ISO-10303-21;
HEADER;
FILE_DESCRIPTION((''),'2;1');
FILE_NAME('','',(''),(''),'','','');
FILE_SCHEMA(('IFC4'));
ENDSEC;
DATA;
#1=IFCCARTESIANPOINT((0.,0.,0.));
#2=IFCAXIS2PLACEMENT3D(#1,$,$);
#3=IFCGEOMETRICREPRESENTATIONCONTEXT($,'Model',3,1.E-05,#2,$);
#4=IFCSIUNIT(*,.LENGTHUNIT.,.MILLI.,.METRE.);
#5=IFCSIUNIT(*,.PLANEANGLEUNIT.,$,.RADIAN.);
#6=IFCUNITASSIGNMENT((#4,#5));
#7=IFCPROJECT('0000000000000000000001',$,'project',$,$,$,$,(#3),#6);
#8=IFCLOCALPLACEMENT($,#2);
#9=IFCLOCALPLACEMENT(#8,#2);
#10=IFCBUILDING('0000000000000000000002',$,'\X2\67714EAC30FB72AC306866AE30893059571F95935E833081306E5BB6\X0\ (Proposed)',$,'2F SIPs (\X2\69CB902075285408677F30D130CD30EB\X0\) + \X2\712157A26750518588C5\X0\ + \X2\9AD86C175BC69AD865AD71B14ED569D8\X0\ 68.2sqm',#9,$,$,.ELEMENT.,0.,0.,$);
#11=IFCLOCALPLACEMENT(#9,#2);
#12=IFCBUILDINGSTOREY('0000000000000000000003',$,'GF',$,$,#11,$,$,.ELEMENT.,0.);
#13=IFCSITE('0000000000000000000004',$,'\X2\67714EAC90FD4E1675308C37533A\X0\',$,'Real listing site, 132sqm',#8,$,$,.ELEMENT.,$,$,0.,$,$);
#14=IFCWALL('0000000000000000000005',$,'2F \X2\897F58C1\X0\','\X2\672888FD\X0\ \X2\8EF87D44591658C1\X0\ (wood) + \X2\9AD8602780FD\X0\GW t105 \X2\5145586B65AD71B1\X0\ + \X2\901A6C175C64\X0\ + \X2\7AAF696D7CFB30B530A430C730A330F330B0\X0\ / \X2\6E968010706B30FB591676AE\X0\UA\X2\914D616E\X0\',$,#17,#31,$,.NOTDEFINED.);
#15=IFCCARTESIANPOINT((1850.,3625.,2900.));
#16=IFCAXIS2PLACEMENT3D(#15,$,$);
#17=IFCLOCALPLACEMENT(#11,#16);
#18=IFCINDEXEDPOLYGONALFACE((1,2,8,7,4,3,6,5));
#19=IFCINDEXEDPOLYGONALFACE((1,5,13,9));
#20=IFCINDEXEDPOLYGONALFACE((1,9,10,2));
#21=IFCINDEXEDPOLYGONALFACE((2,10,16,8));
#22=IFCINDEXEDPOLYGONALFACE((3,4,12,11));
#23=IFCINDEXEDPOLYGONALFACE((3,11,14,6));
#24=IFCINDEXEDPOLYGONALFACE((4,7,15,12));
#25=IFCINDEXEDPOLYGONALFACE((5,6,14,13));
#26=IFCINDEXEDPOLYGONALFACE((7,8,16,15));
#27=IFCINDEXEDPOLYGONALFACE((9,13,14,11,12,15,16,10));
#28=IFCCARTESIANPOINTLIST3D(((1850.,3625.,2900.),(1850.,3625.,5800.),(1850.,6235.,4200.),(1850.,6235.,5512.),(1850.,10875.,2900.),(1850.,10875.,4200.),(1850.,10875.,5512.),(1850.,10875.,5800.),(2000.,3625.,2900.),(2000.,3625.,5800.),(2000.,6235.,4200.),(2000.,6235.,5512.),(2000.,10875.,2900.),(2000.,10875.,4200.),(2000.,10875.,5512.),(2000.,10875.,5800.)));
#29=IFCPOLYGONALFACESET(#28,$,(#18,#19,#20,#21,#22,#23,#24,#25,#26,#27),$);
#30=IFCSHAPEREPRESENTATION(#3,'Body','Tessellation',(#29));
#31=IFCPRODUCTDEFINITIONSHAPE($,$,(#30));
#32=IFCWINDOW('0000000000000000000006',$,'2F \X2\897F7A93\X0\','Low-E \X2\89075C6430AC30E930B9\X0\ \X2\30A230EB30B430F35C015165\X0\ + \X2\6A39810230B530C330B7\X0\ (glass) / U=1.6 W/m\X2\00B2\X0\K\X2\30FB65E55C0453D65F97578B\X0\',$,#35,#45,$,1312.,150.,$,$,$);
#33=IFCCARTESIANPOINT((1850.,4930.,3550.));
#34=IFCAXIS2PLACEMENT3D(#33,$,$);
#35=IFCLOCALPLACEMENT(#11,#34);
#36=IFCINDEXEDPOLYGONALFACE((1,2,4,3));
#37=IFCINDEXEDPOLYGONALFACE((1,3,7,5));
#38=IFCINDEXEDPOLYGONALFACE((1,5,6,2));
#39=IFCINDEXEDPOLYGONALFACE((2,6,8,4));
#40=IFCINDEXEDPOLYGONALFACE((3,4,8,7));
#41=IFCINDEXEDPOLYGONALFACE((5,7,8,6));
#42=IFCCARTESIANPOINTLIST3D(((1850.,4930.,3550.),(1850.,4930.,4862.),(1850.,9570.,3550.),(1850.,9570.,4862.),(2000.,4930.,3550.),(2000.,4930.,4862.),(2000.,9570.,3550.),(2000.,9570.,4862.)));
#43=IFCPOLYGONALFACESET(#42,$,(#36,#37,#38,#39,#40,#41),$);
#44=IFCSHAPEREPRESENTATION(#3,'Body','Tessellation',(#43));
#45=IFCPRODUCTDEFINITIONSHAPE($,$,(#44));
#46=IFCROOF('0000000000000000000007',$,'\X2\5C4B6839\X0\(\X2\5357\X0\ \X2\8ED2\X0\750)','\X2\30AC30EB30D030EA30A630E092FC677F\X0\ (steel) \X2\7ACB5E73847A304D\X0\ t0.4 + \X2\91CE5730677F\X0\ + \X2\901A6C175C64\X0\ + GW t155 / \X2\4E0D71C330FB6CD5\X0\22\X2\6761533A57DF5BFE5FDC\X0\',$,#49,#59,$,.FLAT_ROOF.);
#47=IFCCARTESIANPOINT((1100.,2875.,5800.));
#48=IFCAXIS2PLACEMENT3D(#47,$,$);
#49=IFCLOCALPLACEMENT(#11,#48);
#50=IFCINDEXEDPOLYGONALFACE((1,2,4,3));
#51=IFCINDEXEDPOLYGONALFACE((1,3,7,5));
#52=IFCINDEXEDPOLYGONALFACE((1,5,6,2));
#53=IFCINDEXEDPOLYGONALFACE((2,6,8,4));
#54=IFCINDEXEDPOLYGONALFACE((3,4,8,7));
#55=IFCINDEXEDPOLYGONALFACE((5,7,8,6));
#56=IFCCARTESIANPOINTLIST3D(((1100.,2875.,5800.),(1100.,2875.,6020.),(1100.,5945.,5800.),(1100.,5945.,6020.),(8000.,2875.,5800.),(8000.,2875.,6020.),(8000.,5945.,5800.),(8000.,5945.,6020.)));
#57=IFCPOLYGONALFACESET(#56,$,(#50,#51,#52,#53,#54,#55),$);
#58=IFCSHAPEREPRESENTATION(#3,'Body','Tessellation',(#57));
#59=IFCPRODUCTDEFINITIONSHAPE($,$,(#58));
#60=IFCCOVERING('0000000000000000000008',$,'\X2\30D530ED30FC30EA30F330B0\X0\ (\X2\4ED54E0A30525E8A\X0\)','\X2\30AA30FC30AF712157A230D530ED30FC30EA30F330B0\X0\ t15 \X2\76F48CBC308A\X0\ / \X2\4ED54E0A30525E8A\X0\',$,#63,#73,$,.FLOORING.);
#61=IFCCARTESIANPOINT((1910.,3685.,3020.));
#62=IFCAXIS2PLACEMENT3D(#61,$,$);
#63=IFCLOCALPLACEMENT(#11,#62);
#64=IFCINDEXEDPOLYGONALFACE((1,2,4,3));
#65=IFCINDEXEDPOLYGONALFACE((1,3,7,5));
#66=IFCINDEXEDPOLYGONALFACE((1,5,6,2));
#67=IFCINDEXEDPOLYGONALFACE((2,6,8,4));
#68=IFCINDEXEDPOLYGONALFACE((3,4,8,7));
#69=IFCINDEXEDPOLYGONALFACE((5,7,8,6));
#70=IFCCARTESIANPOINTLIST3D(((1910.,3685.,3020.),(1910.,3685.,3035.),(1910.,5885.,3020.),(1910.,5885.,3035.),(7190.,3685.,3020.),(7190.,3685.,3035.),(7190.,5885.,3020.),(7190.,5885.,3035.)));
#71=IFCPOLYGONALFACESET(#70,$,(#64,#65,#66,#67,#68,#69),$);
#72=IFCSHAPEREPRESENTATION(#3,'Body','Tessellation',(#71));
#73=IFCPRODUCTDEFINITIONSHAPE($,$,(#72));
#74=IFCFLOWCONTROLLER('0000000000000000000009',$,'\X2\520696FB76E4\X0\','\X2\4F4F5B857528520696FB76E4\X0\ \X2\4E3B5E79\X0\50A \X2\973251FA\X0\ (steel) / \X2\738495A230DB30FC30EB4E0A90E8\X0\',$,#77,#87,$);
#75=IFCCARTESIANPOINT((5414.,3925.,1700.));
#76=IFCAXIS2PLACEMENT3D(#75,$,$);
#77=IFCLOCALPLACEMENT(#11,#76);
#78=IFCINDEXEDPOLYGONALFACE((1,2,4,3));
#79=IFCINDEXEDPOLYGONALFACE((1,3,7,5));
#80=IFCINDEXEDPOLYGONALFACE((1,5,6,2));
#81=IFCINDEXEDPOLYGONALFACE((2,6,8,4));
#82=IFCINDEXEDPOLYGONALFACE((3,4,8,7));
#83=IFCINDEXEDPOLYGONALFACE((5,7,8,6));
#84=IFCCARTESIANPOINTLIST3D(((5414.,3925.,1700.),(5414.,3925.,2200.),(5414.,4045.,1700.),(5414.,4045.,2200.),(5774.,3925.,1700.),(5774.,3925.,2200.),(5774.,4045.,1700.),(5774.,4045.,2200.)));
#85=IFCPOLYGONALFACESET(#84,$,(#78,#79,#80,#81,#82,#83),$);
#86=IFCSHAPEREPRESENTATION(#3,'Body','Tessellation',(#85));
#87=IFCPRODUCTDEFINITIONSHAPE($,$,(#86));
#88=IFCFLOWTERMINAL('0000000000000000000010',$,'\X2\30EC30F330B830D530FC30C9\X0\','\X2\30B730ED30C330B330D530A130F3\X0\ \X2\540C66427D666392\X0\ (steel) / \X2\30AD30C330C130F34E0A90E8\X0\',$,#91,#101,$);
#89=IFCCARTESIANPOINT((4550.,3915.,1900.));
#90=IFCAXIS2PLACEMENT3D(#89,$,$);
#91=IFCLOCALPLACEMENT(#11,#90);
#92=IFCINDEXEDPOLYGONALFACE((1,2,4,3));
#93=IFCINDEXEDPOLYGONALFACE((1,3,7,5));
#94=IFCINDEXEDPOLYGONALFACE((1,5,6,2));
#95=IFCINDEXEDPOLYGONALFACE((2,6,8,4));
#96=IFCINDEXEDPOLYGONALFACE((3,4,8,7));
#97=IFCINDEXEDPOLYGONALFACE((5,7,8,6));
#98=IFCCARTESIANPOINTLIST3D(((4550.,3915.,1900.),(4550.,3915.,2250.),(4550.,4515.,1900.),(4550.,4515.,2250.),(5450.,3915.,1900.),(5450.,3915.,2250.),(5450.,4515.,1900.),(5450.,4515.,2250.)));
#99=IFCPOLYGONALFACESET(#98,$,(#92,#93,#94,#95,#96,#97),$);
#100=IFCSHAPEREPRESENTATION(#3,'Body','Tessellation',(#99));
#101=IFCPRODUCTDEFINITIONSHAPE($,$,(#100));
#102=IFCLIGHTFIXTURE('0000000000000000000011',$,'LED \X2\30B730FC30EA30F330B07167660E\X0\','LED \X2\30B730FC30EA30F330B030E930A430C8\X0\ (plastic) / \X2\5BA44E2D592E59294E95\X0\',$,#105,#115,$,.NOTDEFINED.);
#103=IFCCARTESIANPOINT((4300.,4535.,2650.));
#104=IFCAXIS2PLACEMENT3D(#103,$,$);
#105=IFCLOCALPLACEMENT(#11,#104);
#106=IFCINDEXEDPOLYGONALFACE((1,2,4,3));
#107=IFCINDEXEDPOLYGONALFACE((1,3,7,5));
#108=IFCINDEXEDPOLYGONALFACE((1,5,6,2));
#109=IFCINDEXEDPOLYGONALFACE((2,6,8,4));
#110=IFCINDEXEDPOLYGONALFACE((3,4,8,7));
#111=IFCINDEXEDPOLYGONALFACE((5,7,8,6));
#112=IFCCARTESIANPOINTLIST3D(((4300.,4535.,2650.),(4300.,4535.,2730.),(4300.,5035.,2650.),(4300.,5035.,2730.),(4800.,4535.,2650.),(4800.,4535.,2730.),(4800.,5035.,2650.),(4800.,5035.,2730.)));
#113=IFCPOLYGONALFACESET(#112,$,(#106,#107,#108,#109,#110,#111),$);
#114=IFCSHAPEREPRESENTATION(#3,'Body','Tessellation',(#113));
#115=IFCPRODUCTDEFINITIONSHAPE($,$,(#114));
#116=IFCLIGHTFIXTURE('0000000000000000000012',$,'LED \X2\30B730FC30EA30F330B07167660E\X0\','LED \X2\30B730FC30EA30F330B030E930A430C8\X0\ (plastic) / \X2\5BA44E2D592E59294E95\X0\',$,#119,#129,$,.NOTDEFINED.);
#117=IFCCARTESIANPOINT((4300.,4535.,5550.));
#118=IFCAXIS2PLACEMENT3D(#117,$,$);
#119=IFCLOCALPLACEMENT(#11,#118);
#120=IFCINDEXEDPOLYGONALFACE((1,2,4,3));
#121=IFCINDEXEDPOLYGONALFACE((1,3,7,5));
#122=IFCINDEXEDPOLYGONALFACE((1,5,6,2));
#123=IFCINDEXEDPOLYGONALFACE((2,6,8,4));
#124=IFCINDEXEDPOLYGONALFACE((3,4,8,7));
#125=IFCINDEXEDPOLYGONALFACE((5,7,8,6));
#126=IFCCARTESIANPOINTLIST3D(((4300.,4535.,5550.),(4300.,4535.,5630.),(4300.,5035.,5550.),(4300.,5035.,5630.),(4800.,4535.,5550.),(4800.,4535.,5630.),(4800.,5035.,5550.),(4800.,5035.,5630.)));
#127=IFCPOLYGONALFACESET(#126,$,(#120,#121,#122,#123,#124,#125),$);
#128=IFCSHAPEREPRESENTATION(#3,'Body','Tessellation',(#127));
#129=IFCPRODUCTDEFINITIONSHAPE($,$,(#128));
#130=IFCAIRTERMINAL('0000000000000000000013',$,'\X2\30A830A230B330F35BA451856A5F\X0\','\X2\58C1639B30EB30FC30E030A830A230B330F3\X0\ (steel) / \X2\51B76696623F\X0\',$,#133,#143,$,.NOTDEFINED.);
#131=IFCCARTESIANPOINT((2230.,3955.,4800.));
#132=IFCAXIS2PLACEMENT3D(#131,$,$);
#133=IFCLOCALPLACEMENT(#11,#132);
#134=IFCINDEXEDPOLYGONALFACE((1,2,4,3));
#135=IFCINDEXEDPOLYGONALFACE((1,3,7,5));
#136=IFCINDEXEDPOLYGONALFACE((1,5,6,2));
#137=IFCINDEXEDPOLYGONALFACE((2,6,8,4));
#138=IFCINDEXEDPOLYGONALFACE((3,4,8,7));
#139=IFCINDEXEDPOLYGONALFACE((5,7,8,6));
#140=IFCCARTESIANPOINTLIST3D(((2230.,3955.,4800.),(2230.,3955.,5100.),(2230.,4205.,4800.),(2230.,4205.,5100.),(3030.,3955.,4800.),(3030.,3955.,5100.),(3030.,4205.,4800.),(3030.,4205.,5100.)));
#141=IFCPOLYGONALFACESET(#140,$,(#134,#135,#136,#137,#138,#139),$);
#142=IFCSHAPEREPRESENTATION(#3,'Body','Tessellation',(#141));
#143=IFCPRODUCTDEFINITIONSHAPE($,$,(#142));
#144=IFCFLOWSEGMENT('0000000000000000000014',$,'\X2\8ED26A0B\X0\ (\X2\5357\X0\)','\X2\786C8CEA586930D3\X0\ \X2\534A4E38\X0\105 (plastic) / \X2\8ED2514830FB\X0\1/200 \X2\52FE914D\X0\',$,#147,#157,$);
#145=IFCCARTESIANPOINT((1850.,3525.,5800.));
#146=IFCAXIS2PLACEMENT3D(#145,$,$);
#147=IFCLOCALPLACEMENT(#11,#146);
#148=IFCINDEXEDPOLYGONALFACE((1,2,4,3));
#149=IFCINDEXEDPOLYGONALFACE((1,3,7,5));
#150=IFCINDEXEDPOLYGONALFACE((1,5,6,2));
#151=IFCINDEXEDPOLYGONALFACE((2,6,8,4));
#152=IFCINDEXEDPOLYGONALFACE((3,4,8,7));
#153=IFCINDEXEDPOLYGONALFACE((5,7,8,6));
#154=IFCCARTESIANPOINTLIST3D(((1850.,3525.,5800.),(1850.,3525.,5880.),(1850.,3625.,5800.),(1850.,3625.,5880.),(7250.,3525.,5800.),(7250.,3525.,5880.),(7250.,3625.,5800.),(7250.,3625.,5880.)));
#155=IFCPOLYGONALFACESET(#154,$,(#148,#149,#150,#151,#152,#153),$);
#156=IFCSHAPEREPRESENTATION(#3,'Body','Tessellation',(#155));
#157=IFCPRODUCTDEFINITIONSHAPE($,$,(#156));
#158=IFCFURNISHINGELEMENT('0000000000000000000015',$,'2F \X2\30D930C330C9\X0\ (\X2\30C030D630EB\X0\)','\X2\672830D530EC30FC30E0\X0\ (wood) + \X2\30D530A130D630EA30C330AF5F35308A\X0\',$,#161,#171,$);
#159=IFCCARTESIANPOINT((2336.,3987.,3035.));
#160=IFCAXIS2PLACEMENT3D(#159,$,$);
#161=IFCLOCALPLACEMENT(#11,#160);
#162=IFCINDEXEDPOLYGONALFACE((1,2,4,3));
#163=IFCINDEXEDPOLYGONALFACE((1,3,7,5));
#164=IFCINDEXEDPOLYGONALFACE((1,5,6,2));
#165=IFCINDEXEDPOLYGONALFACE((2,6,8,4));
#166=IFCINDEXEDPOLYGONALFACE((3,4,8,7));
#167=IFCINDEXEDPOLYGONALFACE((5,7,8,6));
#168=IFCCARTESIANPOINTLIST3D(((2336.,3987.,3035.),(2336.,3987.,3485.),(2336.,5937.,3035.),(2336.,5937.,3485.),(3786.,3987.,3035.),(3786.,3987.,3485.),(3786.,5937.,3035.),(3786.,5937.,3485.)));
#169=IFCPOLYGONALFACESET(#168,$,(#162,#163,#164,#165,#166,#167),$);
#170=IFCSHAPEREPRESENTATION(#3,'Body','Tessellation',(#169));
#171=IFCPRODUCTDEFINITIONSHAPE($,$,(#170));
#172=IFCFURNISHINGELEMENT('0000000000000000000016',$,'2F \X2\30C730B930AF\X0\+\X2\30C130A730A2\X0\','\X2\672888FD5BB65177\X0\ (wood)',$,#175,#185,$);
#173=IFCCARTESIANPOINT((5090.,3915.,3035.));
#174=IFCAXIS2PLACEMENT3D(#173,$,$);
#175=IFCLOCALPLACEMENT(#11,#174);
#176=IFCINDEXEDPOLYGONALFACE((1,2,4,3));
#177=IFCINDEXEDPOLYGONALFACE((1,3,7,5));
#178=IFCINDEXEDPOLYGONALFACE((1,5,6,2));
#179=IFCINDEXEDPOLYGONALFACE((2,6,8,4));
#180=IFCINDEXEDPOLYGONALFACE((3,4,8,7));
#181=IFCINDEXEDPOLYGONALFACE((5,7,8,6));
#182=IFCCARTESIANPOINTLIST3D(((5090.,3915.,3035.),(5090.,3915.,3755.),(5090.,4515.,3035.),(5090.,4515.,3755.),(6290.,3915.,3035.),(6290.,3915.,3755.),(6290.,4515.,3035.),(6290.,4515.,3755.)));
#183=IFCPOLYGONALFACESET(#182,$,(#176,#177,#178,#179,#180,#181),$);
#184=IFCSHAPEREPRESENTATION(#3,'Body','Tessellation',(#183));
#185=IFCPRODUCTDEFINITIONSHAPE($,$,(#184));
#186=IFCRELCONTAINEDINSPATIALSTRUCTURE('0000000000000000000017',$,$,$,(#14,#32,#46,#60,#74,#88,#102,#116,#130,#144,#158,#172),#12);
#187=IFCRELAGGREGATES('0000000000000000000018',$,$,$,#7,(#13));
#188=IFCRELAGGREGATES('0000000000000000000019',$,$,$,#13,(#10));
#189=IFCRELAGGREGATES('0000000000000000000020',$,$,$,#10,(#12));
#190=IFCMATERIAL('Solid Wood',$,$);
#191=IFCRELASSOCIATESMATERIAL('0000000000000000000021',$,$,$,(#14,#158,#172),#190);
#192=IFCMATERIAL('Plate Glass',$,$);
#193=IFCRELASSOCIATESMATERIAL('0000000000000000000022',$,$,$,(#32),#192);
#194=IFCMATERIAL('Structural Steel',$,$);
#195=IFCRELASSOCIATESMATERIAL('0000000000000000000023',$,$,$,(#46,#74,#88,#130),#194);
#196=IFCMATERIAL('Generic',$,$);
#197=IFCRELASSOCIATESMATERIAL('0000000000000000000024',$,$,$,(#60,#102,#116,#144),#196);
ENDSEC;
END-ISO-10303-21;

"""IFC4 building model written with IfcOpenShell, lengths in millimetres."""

from ifc_helpers import new_model, si_unit, frame, frame_2d, origin, place, context, project, spatial, rectangle, extrude, material, element, fill, save


model = new_model("IFC4")

# Units and contexts
model_context = context("Model", 3, precision=1e-05, world=origin())
ifc_project = project(units=[si_unit("LENGTHUNIT", "METRE", prefix="MILLI"), si_unit("PLANEANGLEUNIT", "RADIAN")], contexts=[model_context])

# Site, building, storey
site_placement = place(None, origin())
site = spatial("IfcSite", under=ifc_project, at=site_placement, Name="東京都世田谷区", ObjectType="Real listing site, 132sqm", CompositionType="ELEMENT", RefElevation=0.0)
building_placement = place(site_placement, origin())
building = spatial("IfcBuilding", under=site, at=building_placement, Name="東京・犬と暮らす土間広めの家 (Proposed)", ObjectType="2F SIPs (構造用合板パネル) + 無垢材内装 + 高気密高断熱仕様 68.2sqm", CompositionType="ELEMENT", ElevationOfRefHeight=0.0, ElevationOfTerrain=0.0)
storey_placement = place(building_placement, origin())
storey = spatial("IfcBuildingStorey", under=building, at=storey_placement, Name="GF", CompositionType="ELEMENT", Elevation=0.0)

# Shared definitions
ifc_material_1 = material(Name="Solid Wood")

# Wall, opening, window
ifc_material_2 = material(Name="Plate Glass")
wall_1_placement = place(storey_placement, frame((1850.0, 3625.0, 2900.0)))
wall_1 = element("IfcWall", 1, at=wall_1_placement, inside=storey, material=ifc_material_1, Name="2F 西壁", Description="木製 軸組外壁 (wood) + 高性能GW t105 充填断熱 + 通気層 + 窯業系サイディング / 準耐火・外皮UA配慮", PredefinedType="NOTDEFINED", context=model_context, shape_type="SweptSolid", body=[
    extrude(rectangle(XDim=150.0, YDim=7250.0, at=frame_2d((75.0, 3625.0))), frame((1850.0, 3625.0, 2900.0)), (0.0, 0.0, 1.0), 2900.0),
])
opening_1_placement = place(storey_placement, frame((1850.0, 4930.0, 3550.0)))
opening_1 = element("IfcOpeningElement", 2, at=opening_1_placement, cuts=wall_1, PredefinedType="NOTDEFINED", context=model_context, shape_type="SweptSolid", body=[
    extrude(rectangle(XDim=150.0, YDim=4640.0, at=frame_2d((75.0, 2320.0))), frame((1850.0, 4930.0, 3550.0)), (0.0, 0.0, 1.0), 1312.0),
])
window_1_placement = place(storey_placement, frame((1850.0, 4930.0, 3550.0)))
window_1 = element("IfcWindow", 3, at=window_1_placement, inside=storey, material=ifc_material_2, Name="2F 西窓", Description="Low-E 複層ガラス アルゴン封入 + 樹脂サッシ (glass) / U=1.6 W/m²K・日射取得型", OverallHeight=1312.0, OverallWidth=150.0, context=model_context, shape_type="SweptSolid", body=[
    extrude(rectangle(XDim=150.0, YDim=4640.0, at=frame_2d((75.0, 2320.0))), frame((1850.0, 4930.0, 3550.0)), (0.0, 0.0, 1.0), 1312.0),
])
fill(opening_1, window_1)

# Roof
ifc_material_3 = material(Name="Structural Steel")
for number, where, name in (
    (4, (1100.0, 2875.0, 5800.0), "屋根(南 軒750)"),
):
    element("IfcRoof", number, at=place(storey_placement, frame(where)), inside=storey, material=ifc_material_3, Name=name, Description="ガルバリウム鋼板 (steel) 立平葺き t0.4 + 野地板 + 通気層 + GW t155 / 不燃・法22条区域対応", PredefinedType="FLAT_ROOF", context=model_context, shape_type="SweptSolid", body=[
        extrude(rectangle(XDim=6900.0, YDim=3070.0, at=frame_2d((3450.0, 1535.0))), frame((1100.0, 2875.0, 5800.0)), (0.0, 0.0, 1.0), 220.0),
    ])

# Covering
ifc_material_4 = material(Name="Generic")
covering_placement = place(storey_placement, frame((1910.0, 3685.0, 3020.0)))
element("IfcCovering", 5, at=covering_placement, inside=storey, material=ifc_material_4, Name="フローリング (仕上げ床)", Description="オーク無垢フローリング t15 直貼り / 仕上げ床", PredefinedType="FLOORING", context=model_context, shape_type="SweptSolid", body=[
    extrude(rectangle(XDim=5280.0, YDim=2200.0, at=frame_2d((2640.0, 1100.0))), frame((1910.0, 3685.0, 3020.0)), (0.0, 0.0, 1.0), 15.0),
])

# Flow controller
flow_controller_placement = place(storey_placement, frame((5414.0, 3925.0, 1700.0)))
element("IfcFlowController", 6, at=flow_controller_placement, inside=storey, material=ifc_material_3, Name="分電盤", Description="住宅用分電盤 主幹50A 露出 (steel) / 玄関ホール上部", context=model_context, shape_type="SweptSolid", body=[
    extrude(rectangle(XDim=360.0, YDim=120.0, at=frame_2d((180.0, 60.0))), frame((5414.0, 3925.0, 1700.0)), (0.0, 0.0, 1.0), 500.0),
])

# Flow terminal
flow_terminal_placement = place(storey_placement, frame((4550.0, 3915.0, 1900.0)))
element("IfcFlowTerminal", 7, at=flow_terminal_placement, inside=storey, material=ifc_material_3, Name="レンジフード", Description="シロッコファン 同時給排 (steel) / キッチン上部", context=model_context, shape_type="SweptSolid", body=[
    extrude(rectangle(XDim=900.0, YDim=600.0, at=frame_2d((450.0, 300.0))), frame((4550.0, 3915.0, 1900.0)), (0.0, 0.0, 1.0), 350.0),
])

# Light fixtures
light_fixture_1_placement = place(storey_placement, frame((4300.0, 4535.0, 2650.0)))
element("IfcLightFixture", 8, at=light_fixture_1_placement, inside=storey, material=ifc_material_4, Name="LED シーリング照明", Description="LED シーリングライト (plastic) / 室中央天井", PredefinedType="NOTDEFINED", context=model_context, shape_type="SweptSolid", body=[
    extrude(rectangle(XDim=500.0, YDim=500.0, at=frame_2d((250.0, 250.0))), frame((4300.0, 4535.0, 2650.0)), (0.0, 0.0, 1.0), 80.0),
])
light_fixture_2_placement = place(storey_placement, frame((4300.0, 4535.0, 5550.0)))
element("IfcLightFixture", 9, at=light_fixture_2_placement, inside=storey, material=ifc_material_4, Name="LED シーリング照明", Description="LED シーリングライト (plastic) / 室中央天井", PredefinedType="NOTDEFINED", context=model_context, shape_type="SweptSolid", body=[
    extrude(rectangle(XDim=500.0, YDim=500.0, at=frame_2d((250.0, 250.0))), frame((4300.0, 4535.0, 5550.0)), (0.0, 0.0, 1.0), 80.0),
])

# Air terminal
air_terminal_placement = place(storey_placement, frame((2230.0, 3955.0, 4800.0)))
element("IfcAirTerminal", 10, at=air_terminal_placement, inside=storey, material=ifc_material_3, Name="エアコン室内機", Description="壁掛ルームエアコン (steel) / 冷暖房", PredefinedType="NOTDEFINED", context=model_context, shape_type="SweptSolid", body=[
    extrude(rectangle(XDim=800.0, YDim=250.0, at=frame_2d((400.0, 125.0))), frame((2230.0, 3955.0, 4800.0)), (0.0, 0.0, 1.0), 300.0),
])

# Flow segment
flow_segment_placement = place(storey_placement, frame((1850.0, 3525.0, 5800.0)))
element("IfcFlowSegment", 11, at=flow_segment_placement, inside=storey, material=ifc_material_4, Name="軒樋 (南)", Description="硬質塩ビ 半丸105 (plastic) / 軒先・1/200 勾配", context=model_context, shape_type="SweptSolid", body=[
    extrude(rectangle(XDim=5400.0, YDim=100.0, at=frame_2d((2700.0, 50.0))), frame((1850.0, 3525.0, 5800.0)), (0.0, 0.0, 1.0), 80.0),
])

# Furnishing elements
furnishing_1_placement = place(storey_placement, frame((2336.0, 3987.0, 3035.0)))
element("IfcFurnishingElement", 12, at=furnishing_1_placement, inside=storey, material=ifc_material_1, Name="2F ベッド (ダブル)", Description="木フレーム (wood) + ファブリック張り", context=model_context, shape_type="SweptSolid", body=[
    extrude(rectangle(XDim=1450.0, YDim=1950.0, at=frame_2d((725.0, 975.0))), frame((2336.0, 3987.0, 3035.0)), (0.0, 0.0, 1.0), 450.0),
])
furnishing_2_placement = place(storey_placement, frame((5090.0, 3915.0, 3035.0)))
element("IfcFurnishingElement", 13, at=furnishing_2_placement, inside=storey, material=ifc_material_1, Name="2F デスク+チェア", Description="木製家具 (wood)", context=model_context, shape_type="SweptSolid", body=[
    extrude(rectangle(XDim=1200.0, YDim=600.0, at=frame_2d((600.0, 300.0))), frame((5090.0, 3915.0, 3035.0)), (0.0, 0.0, 1.0), 720.0),
])

save(model, "model.ifc")
